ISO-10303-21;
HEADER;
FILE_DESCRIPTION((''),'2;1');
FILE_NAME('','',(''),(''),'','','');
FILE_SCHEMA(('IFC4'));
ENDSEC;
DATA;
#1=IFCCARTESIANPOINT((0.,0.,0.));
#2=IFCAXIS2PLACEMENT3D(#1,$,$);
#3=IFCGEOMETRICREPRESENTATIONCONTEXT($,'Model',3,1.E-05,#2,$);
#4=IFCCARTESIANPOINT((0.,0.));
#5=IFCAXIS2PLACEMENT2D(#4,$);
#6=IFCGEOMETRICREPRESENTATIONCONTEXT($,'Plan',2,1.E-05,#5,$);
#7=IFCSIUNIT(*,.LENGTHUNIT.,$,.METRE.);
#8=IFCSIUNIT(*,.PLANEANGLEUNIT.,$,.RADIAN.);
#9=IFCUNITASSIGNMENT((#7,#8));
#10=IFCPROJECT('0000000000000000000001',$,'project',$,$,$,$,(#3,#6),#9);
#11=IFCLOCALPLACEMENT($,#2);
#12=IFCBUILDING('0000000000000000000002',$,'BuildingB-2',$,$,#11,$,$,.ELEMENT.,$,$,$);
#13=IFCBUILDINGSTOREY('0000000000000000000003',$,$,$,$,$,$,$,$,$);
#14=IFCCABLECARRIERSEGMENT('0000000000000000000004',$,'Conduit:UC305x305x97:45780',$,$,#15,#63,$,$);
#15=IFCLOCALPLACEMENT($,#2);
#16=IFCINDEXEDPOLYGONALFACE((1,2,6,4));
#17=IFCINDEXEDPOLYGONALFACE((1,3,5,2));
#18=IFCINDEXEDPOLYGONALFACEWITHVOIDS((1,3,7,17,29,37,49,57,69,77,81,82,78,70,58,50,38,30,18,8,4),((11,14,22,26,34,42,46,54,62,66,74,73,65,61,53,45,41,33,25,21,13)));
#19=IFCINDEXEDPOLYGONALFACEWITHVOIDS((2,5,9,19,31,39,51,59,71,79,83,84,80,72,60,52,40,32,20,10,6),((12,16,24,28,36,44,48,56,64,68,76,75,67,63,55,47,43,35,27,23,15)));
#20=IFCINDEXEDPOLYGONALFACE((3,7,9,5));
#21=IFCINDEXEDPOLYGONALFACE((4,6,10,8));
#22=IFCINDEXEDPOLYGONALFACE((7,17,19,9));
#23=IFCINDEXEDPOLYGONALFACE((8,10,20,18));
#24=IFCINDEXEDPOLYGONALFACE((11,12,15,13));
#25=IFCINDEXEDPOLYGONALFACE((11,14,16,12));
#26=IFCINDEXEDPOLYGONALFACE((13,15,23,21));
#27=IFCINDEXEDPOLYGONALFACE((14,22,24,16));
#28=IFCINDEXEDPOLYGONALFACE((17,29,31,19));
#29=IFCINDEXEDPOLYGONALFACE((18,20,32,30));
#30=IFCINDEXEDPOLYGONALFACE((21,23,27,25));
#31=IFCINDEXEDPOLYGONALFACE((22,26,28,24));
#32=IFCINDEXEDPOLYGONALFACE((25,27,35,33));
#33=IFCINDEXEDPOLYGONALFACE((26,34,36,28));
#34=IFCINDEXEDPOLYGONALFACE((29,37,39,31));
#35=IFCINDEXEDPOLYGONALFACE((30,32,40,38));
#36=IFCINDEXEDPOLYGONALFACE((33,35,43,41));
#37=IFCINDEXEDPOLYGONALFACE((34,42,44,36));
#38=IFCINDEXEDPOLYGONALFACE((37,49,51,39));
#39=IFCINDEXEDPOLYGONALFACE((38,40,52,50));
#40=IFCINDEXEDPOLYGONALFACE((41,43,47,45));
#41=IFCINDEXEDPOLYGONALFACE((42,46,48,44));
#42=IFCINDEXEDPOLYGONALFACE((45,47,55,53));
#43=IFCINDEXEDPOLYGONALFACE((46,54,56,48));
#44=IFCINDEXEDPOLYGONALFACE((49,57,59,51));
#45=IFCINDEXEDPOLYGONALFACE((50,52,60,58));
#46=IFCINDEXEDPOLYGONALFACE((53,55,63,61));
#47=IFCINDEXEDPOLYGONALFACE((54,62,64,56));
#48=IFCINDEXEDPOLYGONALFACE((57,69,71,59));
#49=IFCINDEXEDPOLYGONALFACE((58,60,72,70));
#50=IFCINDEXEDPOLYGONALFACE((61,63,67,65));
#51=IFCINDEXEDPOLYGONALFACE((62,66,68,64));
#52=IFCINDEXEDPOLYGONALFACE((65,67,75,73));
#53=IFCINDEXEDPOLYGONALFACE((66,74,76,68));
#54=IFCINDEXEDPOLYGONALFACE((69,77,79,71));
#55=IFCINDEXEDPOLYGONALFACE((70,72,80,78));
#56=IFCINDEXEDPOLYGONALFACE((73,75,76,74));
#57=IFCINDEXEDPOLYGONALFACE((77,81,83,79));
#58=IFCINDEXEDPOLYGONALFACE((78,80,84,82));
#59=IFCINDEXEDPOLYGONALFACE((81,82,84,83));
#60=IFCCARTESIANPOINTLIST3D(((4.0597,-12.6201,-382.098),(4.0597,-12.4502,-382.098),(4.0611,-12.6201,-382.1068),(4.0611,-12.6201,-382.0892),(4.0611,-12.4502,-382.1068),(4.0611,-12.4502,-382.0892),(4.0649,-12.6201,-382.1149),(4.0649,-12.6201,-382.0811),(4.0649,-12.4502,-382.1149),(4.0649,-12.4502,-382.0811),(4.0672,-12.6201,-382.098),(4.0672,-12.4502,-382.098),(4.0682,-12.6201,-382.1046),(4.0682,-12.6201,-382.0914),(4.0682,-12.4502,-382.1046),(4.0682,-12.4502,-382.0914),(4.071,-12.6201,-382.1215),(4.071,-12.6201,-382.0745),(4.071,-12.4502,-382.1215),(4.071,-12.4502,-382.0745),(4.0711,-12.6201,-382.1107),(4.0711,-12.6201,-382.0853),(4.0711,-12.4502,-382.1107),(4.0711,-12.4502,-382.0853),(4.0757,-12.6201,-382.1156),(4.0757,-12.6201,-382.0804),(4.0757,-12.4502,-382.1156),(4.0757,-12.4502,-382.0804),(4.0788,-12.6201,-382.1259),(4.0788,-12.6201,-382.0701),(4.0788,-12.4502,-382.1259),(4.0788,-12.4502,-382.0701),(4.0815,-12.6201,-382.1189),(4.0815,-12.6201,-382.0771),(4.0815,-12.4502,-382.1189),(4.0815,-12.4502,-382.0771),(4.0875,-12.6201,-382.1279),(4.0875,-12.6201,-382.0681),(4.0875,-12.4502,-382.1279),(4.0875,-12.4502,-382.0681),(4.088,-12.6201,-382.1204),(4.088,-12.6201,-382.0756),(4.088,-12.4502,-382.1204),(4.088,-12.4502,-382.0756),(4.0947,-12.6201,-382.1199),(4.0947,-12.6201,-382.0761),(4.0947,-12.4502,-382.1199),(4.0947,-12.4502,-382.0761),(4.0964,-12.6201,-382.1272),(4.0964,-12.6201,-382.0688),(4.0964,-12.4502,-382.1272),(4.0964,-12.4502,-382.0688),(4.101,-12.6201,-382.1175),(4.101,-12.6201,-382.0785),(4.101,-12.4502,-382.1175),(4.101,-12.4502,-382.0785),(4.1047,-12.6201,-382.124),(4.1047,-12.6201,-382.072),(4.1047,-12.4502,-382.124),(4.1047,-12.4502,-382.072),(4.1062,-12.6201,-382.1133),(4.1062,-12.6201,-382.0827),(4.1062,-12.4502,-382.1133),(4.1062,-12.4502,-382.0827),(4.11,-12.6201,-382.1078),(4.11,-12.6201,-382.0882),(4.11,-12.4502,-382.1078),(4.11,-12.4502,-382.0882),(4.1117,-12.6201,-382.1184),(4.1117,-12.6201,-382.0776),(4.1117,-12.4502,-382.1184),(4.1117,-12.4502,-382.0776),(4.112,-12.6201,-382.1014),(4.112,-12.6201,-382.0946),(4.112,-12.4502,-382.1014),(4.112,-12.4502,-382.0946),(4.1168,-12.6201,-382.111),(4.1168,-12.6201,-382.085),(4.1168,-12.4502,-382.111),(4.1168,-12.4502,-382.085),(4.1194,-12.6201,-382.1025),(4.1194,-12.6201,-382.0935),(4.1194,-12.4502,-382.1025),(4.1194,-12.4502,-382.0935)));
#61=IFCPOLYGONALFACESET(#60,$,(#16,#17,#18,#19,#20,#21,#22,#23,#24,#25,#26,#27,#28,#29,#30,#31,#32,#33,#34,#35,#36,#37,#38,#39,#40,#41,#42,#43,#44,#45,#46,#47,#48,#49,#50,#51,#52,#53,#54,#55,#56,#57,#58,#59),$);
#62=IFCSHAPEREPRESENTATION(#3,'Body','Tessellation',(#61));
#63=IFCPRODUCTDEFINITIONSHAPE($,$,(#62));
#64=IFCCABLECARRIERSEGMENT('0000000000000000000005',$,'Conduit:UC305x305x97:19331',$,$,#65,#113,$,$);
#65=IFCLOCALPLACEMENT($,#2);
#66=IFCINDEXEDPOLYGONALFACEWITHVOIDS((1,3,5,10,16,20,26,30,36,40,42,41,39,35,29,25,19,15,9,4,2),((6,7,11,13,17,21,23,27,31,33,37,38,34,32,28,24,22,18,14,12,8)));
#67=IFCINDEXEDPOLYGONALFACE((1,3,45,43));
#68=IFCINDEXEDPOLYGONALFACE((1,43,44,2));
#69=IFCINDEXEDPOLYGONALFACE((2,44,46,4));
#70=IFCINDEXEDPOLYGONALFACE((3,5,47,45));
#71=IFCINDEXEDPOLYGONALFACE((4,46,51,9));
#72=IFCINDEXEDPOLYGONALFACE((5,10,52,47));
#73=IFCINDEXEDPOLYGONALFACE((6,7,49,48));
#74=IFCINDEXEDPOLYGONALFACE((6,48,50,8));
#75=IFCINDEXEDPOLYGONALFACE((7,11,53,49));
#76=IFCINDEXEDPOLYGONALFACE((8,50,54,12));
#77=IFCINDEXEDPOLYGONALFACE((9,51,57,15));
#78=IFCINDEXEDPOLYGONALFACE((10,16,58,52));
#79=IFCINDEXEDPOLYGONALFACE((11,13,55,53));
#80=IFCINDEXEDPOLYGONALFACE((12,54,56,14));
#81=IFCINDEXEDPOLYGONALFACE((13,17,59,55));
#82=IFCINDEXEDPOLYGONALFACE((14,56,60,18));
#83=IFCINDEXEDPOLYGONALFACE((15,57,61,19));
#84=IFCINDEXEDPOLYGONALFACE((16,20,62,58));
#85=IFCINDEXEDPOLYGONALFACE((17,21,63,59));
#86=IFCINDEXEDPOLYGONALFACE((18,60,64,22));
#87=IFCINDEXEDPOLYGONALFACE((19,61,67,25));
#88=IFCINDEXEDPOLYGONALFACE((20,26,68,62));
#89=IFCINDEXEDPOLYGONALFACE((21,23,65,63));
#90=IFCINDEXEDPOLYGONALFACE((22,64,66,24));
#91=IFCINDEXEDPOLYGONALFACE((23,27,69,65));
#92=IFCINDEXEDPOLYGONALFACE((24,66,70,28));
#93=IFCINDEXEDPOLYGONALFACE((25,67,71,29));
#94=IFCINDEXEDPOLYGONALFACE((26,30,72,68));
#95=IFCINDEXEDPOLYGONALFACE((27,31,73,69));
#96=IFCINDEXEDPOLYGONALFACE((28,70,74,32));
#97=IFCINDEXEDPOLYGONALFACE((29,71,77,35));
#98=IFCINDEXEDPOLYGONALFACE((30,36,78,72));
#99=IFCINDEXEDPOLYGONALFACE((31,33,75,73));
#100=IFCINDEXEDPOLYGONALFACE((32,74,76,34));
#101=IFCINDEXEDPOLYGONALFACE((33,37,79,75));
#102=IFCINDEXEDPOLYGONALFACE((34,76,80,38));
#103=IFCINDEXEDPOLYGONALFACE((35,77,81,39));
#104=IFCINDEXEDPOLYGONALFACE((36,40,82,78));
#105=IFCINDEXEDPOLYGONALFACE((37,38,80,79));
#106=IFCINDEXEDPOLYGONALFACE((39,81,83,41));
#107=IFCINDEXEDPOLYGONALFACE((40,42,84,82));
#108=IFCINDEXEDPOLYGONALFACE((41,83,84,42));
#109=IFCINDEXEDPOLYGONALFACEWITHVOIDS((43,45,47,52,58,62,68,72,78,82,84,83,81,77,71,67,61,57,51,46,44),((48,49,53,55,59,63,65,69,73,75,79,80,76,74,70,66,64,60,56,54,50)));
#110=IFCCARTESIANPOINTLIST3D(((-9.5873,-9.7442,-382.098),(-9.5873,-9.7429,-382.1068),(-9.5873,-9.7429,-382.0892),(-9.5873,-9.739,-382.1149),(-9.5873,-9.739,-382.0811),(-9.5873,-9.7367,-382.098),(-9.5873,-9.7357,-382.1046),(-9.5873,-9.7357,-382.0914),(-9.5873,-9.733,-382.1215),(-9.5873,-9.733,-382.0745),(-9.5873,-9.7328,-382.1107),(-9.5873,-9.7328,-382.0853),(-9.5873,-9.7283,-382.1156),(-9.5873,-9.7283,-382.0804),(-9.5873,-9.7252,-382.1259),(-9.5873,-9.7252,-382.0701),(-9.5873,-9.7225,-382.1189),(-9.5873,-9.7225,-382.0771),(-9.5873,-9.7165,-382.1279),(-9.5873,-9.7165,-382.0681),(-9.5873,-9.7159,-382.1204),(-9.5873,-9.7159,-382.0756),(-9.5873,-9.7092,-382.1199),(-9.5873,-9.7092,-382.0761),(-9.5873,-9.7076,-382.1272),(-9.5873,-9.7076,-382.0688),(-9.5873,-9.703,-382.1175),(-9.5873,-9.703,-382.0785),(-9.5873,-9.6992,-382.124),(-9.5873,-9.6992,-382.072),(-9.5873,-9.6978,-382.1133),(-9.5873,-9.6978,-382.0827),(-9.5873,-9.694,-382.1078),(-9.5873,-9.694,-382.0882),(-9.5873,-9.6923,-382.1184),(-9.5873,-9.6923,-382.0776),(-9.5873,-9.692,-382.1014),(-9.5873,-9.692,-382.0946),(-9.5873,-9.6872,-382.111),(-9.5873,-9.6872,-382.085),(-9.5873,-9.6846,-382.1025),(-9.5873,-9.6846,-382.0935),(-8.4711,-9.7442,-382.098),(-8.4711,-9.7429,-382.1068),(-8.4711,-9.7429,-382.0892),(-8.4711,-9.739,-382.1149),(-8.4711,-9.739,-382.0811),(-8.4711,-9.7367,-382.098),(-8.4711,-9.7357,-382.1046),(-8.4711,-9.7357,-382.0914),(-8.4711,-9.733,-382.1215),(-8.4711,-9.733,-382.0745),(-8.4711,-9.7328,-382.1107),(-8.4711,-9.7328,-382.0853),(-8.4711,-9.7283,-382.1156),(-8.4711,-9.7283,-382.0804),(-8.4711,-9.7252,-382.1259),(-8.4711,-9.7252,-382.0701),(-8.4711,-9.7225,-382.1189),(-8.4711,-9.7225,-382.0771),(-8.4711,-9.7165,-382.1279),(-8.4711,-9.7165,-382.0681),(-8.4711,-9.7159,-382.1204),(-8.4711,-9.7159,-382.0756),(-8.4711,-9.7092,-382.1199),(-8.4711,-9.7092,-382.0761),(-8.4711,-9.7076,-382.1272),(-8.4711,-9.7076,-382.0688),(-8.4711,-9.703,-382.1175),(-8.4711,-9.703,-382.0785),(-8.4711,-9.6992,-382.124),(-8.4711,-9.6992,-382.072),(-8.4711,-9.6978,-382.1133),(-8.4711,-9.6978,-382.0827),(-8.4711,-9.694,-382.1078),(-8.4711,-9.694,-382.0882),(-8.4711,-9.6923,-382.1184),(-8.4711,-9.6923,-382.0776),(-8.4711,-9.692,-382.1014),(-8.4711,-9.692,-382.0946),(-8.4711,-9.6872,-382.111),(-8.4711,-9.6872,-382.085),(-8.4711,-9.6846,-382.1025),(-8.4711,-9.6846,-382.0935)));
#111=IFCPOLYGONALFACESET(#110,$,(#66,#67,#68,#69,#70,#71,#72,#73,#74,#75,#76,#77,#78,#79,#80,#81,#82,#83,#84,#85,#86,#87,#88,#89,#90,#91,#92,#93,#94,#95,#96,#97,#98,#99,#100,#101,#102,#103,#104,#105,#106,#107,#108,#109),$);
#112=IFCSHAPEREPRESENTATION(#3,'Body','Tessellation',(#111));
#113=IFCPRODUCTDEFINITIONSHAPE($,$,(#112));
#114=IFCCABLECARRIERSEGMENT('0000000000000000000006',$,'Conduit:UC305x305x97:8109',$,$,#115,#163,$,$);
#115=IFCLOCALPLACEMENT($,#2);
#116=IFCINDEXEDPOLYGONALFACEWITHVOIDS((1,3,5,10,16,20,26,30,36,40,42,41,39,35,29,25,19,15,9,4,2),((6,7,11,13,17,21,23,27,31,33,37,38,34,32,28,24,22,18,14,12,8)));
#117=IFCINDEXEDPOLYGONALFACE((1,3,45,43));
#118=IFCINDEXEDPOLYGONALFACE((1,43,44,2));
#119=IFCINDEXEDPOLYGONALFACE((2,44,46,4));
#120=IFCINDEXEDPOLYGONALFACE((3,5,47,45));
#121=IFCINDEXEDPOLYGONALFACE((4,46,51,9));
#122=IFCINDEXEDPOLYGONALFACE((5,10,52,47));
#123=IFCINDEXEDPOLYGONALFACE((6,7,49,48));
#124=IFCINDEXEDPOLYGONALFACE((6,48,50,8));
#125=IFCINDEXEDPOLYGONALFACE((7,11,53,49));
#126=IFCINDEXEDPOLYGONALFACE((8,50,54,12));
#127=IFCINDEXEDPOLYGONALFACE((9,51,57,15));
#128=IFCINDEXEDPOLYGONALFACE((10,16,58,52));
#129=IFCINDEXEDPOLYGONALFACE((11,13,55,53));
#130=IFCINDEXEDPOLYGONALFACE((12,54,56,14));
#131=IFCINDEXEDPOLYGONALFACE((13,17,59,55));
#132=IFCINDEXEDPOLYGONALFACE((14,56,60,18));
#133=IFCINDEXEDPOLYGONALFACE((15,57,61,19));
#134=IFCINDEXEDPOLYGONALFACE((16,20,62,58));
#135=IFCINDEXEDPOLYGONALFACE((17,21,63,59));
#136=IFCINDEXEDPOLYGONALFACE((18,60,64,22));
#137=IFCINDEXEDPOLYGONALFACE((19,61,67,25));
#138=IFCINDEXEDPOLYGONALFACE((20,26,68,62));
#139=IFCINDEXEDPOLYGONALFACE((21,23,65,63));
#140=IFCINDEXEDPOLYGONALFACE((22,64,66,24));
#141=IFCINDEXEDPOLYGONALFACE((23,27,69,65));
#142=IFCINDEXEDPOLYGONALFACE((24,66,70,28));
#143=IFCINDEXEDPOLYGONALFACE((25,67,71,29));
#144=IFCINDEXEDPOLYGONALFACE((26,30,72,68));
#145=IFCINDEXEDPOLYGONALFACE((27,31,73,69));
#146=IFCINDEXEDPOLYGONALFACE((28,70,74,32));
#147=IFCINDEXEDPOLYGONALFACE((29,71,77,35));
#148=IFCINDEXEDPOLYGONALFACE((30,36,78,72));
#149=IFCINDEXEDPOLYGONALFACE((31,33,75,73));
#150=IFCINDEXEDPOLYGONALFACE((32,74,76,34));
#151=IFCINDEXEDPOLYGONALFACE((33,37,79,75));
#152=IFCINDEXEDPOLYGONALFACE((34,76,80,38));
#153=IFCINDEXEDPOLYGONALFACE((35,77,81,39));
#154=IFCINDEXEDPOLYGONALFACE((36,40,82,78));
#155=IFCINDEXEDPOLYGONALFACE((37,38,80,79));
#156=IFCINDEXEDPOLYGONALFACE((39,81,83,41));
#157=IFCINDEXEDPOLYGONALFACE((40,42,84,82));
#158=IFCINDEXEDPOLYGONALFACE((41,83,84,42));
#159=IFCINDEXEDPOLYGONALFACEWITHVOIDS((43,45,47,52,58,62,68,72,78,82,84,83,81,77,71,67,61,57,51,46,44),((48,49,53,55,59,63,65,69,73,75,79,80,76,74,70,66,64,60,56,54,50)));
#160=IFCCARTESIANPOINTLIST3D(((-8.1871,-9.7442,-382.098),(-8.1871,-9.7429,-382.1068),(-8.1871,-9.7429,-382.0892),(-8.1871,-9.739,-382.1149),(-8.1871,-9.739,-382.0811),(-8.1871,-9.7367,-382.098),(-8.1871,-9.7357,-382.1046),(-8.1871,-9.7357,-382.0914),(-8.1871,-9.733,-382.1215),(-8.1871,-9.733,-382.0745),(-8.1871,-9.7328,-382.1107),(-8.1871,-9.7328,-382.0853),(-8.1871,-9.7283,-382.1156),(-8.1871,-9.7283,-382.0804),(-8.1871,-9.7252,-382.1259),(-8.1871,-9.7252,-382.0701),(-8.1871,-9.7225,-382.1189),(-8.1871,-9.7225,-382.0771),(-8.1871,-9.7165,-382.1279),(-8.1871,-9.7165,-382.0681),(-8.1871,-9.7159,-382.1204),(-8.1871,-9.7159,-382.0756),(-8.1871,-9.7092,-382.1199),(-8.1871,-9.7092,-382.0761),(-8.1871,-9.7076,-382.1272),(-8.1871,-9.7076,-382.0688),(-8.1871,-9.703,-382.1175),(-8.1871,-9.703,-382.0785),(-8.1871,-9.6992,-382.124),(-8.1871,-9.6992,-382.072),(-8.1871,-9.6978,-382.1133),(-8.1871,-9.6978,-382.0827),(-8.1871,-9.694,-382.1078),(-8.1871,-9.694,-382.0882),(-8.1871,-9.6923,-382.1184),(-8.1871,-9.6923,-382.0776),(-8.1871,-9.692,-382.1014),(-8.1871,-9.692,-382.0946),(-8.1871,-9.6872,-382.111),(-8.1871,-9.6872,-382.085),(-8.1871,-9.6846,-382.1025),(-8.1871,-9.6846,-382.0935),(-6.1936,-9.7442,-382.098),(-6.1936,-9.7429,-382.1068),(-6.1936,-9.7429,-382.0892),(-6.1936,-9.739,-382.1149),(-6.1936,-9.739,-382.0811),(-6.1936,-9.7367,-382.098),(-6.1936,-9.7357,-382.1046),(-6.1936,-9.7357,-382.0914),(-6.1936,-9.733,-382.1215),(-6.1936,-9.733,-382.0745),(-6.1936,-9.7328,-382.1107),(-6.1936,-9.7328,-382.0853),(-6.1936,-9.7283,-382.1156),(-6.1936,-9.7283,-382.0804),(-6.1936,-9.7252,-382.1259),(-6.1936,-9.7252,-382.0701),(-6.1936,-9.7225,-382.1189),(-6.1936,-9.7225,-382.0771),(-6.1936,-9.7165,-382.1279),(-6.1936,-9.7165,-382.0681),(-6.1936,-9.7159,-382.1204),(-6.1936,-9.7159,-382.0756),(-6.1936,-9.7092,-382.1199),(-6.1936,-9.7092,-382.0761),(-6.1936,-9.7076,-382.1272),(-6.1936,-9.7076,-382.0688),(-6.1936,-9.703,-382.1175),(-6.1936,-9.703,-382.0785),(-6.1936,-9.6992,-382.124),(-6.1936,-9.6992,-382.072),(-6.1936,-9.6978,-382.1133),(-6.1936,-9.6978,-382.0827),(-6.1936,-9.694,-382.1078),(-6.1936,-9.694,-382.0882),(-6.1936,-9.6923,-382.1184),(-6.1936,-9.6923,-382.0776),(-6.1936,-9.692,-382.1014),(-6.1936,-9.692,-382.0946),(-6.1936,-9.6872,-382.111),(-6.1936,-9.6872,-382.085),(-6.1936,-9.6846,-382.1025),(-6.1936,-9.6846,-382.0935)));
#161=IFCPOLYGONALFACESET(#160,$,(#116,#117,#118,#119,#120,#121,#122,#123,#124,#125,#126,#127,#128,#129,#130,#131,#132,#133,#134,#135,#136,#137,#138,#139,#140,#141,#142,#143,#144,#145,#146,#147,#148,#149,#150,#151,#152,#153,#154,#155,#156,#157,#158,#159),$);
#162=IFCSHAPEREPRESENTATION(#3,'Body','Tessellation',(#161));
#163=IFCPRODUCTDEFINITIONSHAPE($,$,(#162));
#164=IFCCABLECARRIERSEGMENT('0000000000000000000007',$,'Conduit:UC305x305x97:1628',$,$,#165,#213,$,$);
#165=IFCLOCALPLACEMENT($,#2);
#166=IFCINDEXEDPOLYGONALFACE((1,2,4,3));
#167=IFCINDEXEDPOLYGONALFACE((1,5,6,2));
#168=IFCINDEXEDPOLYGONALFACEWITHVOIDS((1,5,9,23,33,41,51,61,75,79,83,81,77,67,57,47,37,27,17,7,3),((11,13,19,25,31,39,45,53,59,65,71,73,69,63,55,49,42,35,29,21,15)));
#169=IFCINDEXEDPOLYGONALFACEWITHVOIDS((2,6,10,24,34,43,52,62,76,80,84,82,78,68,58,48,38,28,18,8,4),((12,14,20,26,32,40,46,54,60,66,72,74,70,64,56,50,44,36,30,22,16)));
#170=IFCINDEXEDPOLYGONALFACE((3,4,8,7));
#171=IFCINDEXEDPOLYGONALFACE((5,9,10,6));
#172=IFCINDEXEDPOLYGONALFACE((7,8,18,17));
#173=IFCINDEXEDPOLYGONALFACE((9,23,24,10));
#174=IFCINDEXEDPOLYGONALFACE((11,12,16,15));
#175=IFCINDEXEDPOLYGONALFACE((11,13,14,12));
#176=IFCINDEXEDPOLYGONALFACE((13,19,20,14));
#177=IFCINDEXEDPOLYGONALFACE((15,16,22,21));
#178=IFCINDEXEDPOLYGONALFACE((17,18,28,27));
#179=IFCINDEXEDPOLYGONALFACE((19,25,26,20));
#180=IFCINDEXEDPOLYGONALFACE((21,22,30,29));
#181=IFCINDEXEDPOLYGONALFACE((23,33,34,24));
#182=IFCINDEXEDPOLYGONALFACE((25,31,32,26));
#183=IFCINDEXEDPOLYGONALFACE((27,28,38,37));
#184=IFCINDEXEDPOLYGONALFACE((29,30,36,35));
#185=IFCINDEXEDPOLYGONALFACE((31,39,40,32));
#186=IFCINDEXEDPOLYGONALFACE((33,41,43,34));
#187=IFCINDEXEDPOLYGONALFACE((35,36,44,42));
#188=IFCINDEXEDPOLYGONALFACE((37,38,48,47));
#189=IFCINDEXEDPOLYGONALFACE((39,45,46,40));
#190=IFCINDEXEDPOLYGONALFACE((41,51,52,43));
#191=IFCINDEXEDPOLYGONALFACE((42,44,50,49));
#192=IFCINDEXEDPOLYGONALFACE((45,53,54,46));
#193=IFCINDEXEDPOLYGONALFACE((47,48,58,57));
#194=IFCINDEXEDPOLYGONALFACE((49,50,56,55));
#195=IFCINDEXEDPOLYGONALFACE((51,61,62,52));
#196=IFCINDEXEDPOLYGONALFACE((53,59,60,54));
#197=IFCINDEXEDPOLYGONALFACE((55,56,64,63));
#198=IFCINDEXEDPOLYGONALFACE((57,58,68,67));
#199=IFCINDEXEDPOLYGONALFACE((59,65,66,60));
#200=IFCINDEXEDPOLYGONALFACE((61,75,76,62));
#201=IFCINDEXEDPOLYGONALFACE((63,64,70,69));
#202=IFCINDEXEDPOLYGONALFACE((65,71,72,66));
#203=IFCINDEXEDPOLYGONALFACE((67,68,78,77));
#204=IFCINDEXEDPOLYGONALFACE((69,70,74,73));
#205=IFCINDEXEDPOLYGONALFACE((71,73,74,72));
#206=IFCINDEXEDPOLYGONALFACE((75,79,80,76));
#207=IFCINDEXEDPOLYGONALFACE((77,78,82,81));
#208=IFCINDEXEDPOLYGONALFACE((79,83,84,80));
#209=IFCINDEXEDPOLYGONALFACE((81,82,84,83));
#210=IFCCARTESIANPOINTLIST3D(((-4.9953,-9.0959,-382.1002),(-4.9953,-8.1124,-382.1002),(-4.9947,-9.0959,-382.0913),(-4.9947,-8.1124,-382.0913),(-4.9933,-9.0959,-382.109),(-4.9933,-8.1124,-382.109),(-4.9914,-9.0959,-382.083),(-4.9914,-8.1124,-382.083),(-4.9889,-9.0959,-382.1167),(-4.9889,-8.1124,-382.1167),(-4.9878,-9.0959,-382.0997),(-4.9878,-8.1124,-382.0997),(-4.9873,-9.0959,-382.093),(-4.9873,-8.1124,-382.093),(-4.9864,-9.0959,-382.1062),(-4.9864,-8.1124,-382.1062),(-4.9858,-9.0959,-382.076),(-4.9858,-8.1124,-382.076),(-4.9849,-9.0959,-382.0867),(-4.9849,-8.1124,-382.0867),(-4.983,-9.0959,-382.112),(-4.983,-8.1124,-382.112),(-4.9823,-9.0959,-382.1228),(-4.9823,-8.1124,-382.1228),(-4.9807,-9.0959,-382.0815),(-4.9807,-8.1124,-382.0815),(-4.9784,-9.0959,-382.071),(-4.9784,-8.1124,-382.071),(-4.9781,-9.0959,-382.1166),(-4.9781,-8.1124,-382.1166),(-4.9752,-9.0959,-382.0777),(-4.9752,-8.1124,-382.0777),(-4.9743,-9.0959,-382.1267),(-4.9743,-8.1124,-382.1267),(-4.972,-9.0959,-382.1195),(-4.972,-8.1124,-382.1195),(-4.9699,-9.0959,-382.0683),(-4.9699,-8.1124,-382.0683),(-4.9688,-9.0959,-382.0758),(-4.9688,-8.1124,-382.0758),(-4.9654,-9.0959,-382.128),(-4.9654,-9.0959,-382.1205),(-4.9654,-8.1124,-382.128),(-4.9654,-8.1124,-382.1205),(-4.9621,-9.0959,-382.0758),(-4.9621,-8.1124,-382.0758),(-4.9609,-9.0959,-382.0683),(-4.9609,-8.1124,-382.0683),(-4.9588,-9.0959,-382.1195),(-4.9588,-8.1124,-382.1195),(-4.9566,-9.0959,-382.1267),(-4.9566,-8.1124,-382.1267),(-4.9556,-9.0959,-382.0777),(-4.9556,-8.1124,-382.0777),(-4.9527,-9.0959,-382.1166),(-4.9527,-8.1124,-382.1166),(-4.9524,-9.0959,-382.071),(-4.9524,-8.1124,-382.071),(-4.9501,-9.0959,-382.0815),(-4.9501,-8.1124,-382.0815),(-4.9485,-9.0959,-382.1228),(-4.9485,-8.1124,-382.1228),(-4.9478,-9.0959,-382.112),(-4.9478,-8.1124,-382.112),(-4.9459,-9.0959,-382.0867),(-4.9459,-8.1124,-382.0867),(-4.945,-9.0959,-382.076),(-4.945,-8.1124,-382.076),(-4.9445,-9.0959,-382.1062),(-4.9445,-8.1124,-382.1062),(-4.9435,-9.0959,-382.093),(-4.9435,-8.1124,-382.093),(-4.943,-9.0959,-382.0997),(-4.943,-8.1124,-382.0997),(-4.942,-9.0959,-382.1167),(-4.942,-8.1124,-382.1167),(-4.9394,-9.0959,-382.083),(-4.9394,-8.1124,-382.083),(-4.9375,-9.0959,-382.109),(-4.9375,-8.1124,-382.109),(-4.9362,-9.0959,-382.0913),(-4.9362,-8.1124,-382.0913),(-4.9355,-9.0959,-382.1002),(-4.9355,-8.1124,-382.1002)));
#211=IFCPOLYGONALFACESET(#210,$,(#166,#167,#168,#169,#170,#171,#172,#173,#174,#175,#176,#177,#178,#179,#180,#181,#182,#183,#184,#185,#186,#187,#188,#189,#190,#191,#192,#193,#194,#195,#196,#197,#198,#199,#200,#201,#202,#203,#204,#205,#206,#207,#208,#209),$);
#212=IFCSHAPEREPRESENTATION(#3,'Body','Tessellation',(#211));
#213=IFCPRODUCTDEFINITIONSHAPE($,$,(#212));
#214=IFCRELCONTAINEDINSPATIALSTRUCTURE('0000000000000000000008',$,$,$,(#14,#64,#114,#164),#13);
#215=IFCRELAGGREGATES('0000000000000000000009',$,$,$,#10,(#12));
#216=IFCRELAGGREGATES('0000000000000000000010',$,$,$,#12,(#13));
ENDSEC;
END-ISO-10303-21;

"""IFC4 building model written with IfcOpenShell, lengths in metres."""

from ifc_helpers import new_model, entity, si_unit, origin, origin_2d, place, context, project, spatial, element, save


model = new_model("IFC4")

# Units and contexts
model_context = context("Model", 3, precision=1e-05, world=origin())
plan_context = context("Plan", 2, precision=1e-05, world=origin_2d())
ifc_project = project(units=[si_unit("LENGTHUNIT", "METRE"), si_unit("PLANEANGLEUNIT", "RADIAN")], contexts=[model_context, plan_context])

# Building, storey
building_placement = place(None, origin())
building = spatial("IfcBuilding", under=ifc_project, at=building_placement, Name="BuildingB-2", CompositionType="ELEMENT")
storey = spatial("IfcBuildingStorey", under=building)

# Cable carrier segments
element("IfcCableCarrierSegment", 1, inside=storey, Name="Conduit:UC305x305x97:45780", context=model_context, shape_type="AdvancedSweptSolid", body=[
    entity("IfcSweptDiskSolid", entity("IfcCompositeCurve", [entity("IfcCompositeCurveSegment", "CONTINUOUS", False, entity("IfcPolyline", [entity("IfcCartesianPoint", [-4.0897, 12.6201, 382.098]), entity("IfcCartesianPoint", [-4.0897, 12.4502, 382.098])]))], False), 0.03, 0.0225),
])
element("IfcCableCarrierSegment", 2, inside=storey, Name="Conduit:UC305x305x97:19331", context=model_context, shape_type="AdvancedSweptSolid", body=[
    entity("IfcSweptDiskSolid", entity("IfcCompositeCurve", [entity("IfcCompositeCurveSegment", "CONTINUOUS", False, entity("IfcPolyline", [entity("IfcCartesianPoint", [9.5873, 9.7142, 382.098]), entity("IfcCartesianPoint", [8.4711, 9.7142, 382.098])]))], False), 0.03, 0.0225),
])
element("IfcCableCarrierSegment", 3, inside=storey, Name="Conduit:UC305x305x97:8109", context=model_context, shape_type="AdvancedSweptSolid", body=[
    entity("IfcSweptDiskSolid", entity("IfcCompositeCurve", [entity("IfcCompositeCurveSegment", "CONTINUOUS", False, entity("IfcPolyline", [entity("IfcCartesianPoint", [8.1871, 9.7142, 382.098]), entity("IfcCartesianPoint", [6.1936, 9.7142, 382.098])]))], False), 0.03, 0.0225),
])
element("IfcCableCarrierSegment", 4, inside=storey, Name="Conduit:UC305x305x97:1628", context=model_context, shape_type="AdvancedSweptSolid", body=[
    entity("IfcSweptDiskSolid", entity("IfcCompositeCurve", [entity("IfcCompositeCurveSegment", "CONTINUOUS", False, entity("IfcPolyline", [entity("IfcCartesianPoint", [4.9654, 9.0959, 382.098]), entity("IfcCartesianPoint", [4.9654, 8.1124, 382.098])]))], False), 0.03, 0.0225),
])

save(model, "model.ifc")
